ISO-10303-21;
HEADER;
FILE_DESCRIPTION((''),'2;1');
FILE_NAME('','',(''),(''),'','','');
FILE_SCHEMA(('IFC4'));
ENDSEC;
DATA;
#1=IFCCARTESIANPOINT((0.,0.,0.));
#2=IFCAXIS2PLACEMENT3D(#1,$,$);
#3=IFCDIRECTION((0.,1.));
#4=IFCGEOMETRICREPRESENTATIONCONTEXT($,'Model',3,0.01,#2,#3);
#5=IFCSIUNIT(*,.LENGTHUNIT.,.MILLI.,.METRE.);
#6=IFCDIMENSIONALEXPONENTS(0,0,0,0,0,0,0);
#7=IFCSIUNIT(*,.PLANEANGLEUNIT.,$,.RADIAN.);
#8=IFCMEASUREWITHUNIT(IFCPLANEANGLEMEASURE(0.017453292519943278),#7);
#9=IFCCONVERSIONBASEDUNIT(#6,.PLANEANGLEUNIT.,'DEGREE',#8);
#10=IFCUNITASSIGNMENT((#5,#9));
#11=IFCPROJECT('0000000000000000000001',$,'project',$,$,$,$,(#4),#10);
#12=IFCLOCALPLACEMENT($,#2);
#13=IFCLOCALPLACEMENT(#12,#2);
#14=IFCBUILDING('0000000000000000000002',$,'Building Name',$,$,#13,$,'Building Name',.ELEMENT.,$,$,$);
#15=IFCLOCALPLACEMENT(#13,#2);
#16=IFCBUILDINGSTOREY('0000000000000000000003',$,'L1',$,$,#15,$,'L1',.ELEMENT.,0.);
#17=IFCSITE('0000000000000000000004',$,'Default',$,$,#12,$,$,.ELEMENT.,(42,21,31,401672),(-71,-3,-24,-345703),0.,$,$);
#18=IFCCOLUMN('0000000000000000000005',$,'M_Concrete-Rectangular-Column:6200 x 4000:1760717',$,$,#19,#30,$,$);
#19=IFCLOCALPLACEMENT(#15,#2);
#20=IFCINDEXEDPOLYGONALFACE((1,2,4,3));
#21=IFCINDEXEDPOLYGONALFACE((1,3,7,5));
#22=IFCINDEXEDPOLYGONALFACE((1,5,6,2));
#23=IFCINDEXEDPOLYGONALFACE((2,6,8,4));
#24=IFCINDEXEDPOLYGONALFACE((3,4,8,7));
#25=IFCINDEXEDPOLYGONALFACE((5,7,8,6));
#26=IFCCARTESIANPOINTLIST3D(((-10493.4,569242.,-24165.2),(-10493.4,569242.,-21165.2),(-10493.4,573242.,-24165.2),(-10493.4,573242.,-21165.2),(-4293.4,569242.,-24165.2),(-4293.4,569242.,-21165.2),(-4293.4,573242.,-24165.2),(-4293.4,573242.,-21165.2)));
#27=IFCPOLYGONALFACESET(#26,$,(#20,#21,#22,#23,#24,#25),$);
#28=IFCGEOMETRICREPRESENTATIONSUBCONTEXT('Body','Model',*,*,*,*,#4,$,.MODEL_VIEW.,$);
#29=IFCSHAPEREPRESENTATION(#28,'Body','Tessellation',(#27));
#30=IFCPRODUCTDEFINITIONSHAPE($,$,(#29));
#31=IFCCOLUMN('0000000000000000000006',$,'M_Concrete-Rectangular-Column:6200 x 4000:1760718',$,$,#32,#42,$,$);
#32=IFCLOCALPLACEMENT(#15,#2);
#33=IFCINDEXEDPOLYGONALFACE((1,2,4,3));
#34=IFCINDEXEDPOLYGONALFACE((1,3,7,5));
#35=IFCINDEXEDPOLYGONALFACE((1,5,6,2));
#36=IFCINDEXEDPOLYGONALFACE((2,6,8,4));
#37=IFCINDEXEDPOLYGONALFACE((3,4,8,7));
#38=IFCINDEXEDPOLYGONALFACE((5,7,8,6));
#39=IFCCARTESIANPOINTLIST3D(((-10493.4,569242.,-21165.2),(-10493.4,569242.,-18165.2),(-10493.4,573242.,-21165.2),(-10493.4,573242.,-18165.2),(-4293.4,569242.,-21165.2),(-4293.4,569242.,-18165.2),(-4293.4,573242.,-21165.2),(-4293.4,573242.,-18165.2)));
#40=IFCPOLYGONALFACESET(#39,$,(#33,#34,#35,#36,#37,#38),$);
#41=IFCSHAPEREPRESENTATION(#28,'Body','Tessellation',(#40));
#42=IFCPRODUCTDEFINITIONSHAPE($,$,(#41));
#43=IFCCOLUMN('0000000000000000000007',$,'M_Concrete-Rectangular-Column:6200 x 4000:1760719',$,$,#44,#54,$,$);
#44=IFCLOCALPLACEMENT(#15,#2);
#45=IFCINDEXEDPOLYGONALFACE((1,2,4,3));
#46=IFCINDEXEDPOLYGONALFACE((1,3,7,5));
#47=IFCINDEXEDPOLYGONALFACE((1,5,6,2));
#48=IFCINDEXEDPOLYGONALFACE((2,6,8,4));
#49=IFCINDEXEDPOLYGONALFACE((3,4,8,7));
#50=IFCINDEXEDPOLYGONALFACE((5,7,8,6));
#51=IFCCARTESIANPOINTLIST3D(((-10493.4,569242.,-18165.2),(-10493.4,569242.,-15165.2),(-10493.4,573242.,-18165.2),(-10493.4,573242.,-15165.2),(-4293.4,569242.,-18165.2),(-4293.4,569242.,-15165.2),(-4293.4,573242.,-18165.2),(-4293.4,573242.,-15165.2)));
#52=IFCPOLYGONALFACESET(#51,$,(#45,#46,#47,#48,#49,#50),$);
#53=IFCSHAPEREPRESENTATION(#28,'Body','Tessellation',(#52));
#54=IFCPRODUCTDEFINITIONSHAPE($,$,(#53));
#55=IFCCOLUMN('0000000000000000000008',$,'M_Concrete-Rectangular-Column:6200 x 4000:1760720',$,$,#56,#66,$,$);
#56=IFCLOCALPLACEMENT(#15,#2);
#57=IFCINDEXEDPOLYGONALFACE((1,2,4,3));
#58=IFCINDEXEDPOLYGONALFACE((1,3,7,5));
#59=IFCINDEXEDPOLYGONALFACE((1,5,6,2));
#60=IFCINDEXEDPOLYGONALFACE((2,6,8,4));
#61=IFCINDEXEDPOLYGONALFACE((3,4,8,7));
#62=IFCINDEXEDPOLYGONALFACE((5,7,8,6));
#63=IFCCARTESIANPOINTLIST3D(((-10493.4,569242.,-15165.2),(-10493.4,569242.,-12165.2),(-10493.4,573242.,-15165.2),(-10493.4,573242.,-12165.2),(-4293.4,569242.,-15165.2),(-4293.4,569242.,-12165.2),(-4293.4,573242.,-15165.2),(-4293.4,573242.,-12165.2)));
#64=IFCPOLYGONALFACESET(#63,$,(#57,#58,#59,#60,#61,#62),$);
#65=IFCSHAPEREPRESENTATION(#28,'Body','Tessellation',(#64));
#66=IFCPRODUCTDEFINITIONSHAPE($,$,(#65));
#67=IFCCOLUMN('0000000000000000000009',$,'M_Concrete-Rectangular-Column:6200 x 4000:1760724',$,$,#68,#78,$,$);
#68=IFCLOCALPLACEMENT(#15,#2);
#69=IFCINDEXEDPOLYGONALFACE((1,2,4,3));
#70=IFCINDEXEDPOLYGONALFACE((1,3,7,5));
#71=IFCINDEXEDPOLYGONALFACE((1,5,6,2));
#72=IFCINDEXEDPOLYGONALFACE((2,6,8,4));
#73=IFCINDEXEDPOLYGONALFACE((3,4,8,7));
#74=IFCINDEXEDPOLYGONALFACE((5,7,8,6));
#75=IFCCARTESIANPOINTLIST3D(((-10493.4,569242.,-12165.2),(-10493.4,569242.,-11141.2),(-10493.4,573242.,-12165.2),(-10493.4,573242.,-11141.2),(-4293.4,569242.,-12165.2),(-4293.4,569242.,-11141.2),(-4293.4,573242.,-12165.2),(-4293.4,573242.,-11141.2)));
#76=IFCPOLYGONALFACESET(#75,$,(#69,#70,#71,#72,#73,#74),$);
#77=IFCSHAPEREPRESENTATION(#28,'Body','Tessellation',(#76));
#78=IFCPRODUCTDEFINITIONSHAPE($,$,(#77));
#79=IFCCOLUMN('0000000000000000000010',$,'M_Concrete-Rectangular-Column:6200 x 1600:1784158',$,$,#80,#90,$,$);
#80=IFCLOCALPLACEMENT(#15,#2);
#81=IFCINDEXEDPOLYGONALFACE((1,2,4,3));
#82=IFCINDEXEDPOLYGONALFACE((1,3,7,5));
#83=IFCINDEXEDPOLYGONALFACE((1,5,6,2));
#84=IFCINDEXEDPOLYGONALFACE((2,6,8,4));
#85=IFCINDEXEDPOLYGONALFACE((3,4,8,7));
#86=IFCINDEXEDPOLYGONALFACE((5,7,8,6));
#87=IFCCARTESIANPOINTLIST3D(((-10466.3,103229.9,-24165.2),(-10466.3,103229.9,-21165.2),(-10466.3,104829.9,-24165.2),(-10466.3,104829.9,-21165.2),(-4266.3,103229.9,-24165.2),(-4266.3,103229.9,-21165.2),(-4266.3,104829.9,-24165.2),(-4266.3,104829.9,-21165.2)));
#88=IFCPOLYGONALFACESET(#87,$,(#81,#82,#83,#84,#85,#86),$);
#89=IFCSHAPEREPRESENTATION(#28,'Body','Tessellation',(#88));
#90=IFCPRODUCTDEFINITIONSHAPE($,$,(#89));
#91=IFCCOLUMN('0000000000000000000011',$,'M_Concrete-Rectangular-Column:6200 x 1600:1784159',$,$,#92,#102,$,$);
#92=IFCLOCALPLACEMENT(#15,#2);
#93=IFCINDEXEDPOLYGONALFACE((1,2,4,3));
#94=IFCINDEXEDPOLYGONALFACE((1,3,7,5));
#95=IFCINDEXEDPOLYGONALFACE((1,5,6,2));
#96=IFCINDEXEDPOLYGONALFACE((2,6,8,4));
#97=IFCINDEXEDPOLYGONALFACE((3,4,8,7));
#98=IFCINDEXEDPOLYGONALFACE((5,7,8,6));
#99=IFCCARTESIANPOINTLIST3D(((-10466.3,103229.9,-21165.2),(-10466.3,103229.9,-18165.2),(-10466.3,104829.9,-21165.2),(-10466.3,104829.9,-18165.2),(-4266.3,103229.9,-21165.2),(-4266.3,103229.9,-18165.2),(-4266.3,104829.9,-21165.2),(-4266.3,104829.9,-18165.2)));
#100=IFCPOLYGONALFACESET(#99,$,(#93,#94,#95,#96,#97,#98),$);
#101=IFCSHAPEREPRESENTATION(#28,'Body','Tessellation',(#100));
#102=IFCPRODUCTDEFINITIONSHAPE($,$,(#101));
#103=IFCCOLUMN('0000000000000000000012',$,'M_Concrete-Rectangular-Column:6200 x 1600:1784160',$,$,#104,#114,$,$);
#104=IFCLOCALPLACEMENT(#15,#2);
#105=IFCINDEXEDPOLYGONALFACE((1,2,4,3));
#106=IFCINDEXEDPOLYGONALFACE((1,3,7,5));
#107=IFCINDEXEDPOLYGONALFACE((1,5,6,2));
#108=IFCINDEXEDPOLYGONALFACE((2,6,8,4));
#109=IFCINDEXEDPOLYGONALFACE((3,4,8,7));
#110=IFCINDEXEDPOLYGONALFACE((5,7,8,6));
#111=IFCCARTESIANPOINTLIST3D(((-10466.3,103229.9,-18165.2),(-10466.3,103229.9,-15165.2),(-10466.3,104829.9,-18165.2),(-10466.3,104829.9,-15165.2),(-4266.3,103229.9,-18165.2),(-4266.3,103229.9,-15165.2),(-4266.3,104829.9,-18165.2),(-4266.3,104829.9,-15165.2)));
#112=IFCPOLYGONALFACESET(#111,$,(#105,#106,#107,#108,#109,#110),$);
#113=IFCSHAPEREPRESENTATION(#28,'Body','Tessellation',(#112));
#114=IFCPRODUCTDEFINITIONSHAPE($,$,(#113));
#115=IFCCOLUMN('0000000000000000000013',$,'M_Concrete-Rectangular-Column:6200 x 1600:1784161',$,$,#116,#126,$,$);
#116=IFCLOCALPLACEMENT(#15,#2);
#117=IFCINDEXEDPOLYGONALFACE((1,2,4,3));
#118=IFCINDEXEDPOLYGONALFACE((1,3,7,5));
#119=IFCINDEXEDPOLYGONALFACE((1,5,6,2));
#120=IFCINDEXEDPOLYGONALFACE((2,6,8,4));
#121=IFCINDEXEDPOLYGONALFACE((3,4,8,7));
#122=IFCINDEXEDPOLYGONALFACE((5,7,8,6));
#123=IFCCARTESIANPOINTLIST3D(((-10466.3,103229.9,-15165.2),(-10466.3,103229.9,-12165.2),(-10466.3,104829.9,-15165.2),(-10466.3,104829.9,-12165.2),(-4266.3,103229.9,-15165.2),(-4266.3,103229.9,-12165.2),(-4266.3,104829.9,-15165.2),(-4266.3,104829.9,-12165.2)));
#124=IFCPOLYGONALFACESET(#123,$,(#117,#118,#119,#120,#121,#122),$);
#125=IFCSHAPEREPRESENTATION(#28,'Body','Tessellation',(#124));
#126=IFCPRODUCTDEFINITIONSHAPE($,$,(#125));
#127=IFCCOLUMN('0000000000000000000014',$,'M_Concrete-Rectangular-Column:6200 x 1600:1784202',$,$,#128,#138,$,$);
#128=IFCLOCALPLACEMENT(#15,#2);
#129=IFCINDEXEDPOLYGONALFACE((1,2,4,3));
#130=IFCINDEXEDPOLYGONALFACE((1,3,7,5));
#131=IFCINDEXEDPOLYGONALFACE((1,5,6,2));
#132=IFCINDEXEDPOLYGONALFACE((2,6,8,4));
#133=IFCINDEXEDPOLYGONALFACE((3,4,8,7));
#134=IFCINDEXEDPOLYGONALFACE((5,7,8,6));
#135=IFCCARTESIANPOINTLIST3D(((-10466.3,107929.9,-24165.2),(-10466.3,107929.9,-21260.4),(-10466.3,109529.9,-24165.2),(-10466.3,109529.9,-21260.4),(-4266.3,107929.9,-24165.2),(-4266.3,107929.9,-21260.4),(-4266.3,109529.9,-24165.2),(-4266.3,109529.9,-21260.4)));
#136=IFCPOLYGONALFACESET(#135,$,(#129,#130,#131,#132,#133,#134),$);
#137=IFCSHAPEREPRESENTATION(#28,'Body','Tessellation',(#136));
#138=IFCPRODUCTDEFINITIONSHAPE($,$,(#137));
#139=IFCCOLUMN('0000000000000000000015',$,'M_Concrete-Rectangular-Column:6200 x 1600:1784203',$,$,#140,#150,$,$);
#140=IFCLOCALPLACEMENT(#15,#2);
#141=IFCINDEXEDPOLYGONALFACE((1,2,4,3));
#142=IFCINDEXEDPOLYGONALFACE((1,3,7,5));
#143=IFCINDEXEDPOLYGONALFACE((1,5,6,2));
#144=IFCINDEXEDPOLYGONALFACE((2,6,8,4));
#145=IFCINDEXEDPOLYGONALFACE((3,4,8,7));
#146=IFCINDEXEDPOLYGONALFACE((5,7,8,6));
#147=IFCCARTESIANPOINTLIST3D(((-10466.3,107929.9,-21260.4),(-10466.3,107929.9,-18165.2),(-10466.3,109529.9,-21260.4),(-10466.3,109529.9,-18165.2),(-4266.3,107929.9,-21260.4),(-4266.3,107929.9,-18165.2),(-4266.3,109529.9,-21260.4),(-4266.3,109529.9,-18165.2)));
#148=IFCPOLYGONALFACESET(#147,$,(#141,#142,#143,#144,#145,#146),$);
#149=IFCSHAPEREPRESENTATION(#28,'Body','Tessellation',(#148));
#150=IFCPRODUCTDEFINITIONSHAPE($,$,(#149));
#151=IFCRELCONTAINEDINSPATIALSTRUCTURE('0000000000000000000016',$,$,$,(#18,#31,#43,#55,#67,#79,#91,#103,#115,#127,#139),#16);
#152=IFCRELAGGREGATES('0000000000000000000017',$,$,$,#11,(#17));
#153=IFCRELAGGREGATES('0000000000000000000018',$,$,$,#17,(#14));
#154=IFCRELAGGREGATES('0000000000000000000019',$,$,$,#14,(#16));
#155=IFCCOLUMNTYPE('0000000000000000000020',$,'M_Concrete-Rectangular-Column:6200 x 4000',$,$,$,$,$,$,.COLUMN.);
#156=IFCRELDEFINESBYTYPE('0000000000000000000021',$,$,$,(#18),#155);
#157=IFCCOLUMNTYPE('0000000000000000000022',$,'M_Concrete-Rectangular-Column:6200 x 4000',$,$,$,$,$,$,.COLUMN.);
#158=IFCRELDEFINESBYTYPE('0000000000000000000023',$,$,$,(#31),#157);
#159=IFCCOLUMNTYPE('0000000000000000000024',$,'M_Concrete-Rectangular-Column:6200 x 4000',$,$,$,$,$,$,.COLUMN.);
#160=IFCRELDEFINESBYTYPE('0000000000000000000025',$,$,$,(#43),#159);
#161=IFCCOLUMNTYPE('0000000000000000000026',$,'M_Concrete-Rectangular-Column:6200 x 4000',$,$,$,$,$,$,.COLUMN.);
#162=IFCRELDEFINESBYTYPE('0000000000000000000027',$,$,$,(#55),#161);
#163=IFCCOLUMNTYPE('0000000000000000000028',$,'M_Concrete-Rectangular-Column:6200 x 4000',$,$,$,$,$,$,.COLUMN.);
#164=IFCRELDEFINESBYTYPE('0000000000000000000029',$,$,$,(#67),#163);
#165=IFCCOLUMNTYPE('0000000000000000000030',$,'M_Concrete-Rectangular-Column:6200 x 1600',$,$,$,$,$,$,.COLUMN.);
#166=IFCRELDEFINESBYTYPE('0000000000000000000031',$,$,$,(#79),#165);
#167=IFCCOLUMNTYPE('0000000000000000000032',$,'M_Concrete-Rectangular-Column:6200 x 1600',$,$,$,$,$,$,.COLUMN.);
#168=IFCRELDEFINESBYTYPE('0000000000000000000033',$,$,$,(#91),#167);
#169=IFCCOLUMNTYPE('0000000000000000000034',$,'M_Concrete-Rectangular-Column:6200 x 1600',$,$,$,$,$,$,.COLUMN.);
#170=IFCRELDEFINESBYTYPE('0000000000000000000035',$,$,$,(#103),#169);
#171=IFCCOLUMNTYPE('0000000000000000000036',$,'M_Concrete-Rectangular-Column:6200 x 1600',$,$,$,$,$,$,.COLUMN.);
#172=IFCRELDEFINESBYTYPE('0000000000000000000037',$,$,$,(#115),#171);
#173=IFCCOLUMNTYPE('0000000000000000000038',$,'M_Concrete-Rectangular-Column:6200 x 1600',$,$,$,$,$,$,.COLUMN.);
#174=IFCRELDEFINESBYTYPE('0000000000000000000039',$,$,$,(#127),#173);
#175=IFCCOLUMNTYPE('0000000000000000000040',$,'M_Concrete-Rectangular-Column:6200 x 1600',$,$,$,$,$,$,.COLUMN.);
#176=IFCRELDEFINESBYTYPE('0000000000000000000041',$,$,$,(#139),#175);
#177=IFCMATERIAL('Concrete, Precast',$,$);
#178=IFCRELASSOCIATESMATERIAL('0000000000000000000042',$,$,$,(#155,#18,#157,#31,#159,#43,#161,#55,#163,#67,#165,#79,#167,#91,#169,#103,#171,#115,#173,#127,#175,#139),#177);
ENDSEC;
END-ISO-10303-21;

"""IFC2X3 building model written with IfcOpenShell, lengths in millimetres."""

from ifc_helpers import new_model, entity, si_unit, converted_unit, direction, frame, frame_2d, origin, origin_2d_with_axis, place, context, subcontext, project, spatial, rectangle, extrude, source, transform, mapped, material, type_object, type_shapes, element, save


model = new_model("IFC2X3")

# Units and contexts
model_context = context("Model", 3, precision=0.01, world=origin(), true_north=direction((0.0, 1.0)))
body_context = subcontext(model_context, "Body", "Model", "MODEL_VIEW")
ifc_project = project(units=[si_unit("LENGTHUNIT", "METRE", prefix="MILLI"), converted_unit("PLANEANGLEUNIT", "DEGREE", entity("IfcPlaneAngleMeasure", 0.017453292519943278), si_unit("PLANEANGLEUNIT", "RADIAN"), dimensions=[0, 0, 0, 0, 0, 0, 0])], contexts=[model_context])

# Site, building, storey
site_placement = place(None, origin())
site = spatial("IfcSite", under=ifc_project, at=site_placement, Name="Default", CompositionType="ELEMENT", RefLatitude=(42, 21, 31, 401672), RefLongitude=(-71, -3, -24, -345703), RefElevation=0.0)
building_placement = place(site_placement, origin())
building = spatial("IfcBuilding", under=site, at=building_placement, Name="Building Name", LongName="Building Name", CompositionType="ELEMENT")
storey_placement = place(building_placement, origin())
storey = spatial("IfcBuildingStorey", under=building, at=storey_placement, Name="L1", LongName="L1", CompositionType="ELEMENT", Elevation=0.0)

# Columns
ifc_material_1 = material(Name="Concrete, Precast")
column_type_1 = type_object("IfcColumnType", Name="M_Concrete-Rectangular-Column:6200 x 4000", PredefinedType="COLUMN", material=ifc_material_1)
shared_shape_1 = source(origin(), body_context, "Body", "SweptSolid", [
    extrude(rectangle(XDim=4000.0, YDim=6200.0, at=frame_2d((0.0, 0.0), x_axis=(1.0, 0.0))), frame((-7393.4, 571242.0, -24165.2), z_axis=(0.0, 0.0, 1.0), x_axis=(0.0, -1.0, 0.0)), (0.0, 0.0, 1.0), 3000.0),
])
type_shapes(column_type_1, [shared_shape_1])
column_1_placement = place(storey_placement, origin())
element("IfcColumn", 1, at=column_1_placement, inside=storey, type_object=column_type_1, material=ifc_material_1, Name="M_Concrete-Rectangular-Column:6200 x 4000:1760717", context=body_context, shape_type="MappedRepresentation", body=[
    mapped(shared_shape_1, transform((0.0, 0.0, 0.0), scale=1.0)),
])
column_type_2 = type_object("IfcColumnType", Name="M_Concrete-Rectangular-Column:6200 x 4000", PredefinedType="COLUMN", material=ifc_material_1)
shared_shape_2 = source(origin(), body_context, "Body", "SweptSolid", [
    extrude(rectangle(XDim=4000.0, YDim=6200.0, at=frame_2d((0.0, 0.0), x_axis=(1.0, 0.0))), frame((-7393.4, 571242.0, -21165.2), z_axis=(0.0, 0.0, 1.0), x_axis=(0.0, -1.0, 0.0)), (0.0, 0.0, 1.0), 3000.0),
])
type_shapes(column_type_2, [shared_shape_2])
column_2_placement = place(storey_placement, origin())
element("IfcColumn", 2, at=column_2_placement, inside=storey, type_object=column_type_2, material=ifc_material_1, Name="M_Concrete-Rectangular-Column:6200 x 4000:1760718", context=body_context, shape_type="MappedRepresentation", body=[
    mapped(shared_shape_2, transform((0.0, 0.0, 0.0), scale=1.0)),
])
column_type_3 = type_object("IfcColumnType", Name="M_Concrete-Rectangular-Column:6200 x 4000", PredefinedType="COLUMN", material=ifc_material_1)
shared_shape_3 = source(origin(), body_context, "Body", "SweptSolid", [
    extrude(rectangle(XDim=4000.0, YDim=6200.0, at=frame_2d((0.0, 0.0), x_axis=(1.0, 0.0))), frame((-7393.4, 571242.0, -18165.2), z_axis=(0.0, 0.0, 1.0), x_axis=(0.0, -1.0, 0.0)), (0.0, 0.0, 1.0), 3000.0),
])
type_shapes(column_type_3, [shared_shape_3])
column_3_placement = place(storey_placement, origin())
element("IfcColumn", 3, at=column_3_placement, inside=storey, type_object=column_type_3, material=ifc_material_1, Name="M_Concrete-Rectangular-Column:6200 x 4000:1760719", context=body_context, shape_type="MappedRepresentation", body=[
    mapped(shared_shape_3, transform((0.0, 0.0, 0.0), scale=1.0)),
])
column_type_4 = type_object("IfcColumnType", Name="M_Concrete-Rectangular-Column:6200 x 4000", PredefinedType="COLUMN", material=ifc_material_1)
shared_shape_4 = source(origin(), body_context, "Body", "SweptSolid", [
    extrude(rectangle(XDim=4000.0, YDim=6200.0, at=frame_2d((0.0, 0.0), x_axis=(1.0, 0.0))), frame((-7393.4, 571242.0, -15165.2), z_axis=(0.0, 0.0, 1.0), x_axis=(0.0, -1.0, 0.0)), (0.0, 0.0, 1.0), 3000.0),
])
type_shapes(column_type_4, [shared_shape_4])
column_4_placement = place(storey_placement, origin())
element("IfcColumn", 4, at=column_4_placement, inside=storey, type_object=column_type_4, material=ifc_material_1, Name="M_Concrete-Rectangular-Column:6200 x 4000:1760720", context=body_context, shape_type="MappedRepresentation", body=[
    mapped(shared_shape_4, transform((0.0, 0.0, 0.0), scale=1.0)),
])
column_type_5 = type_object("IfcColumnType", Name="M_Concrete-Rectangular-Column:6200 x 4000", PredefinedType="COLUMN", material=ifc_material_1)
shared_shape_5 = source(origin(), body_context, "Body", "SweptSolid", [
    extrude(rectangle(XDim=4000.0, YDim=6200.0, at=origin_2d_with_axis()), frame((-7393.4, 571242.0, -12165.2), z_axis=(0.0, 0.0, 1.0), x_axis=(0.0, -1.0, 0.0)), (0.0, 0.0, 1.0), 1024.0),
])
type_shapes(column_type_5, [shared_shape_5])
column_5_placement = place(storey_placement, origin())
element("IfcColumn", 5, at=column_5_placement, inside=storey, type_object=column_type_5, material=ifc_material_1, Name="M_Concrete-Rectangular-Column:6200 x 4000:1760724", context=body_context, shape_type="MappedRepresentation", body=[
    mapped(shared_shape_5, transform((0.0, 0.0, 0.0), scale=1.0)),
])
column_type_6 = type_object("IfcColumnType", Name="M_Concrete-Rectangular-Column:6200 x 1600", PredefinedType="COLUMN", material=ifc_material_1)
shared_shape_6 = source(origin(), body_context, "Body", "SweptSolid", [
    extrude(rectangle(XDim=1600.0, YDim=6200.0, at=frame_2d((0.0, 0.0), x_axis=(1.0, 0.0))), frame((-7366.3, 104029.9, -24165.2), z_axis=(0.0, 0.0, 1.0), x_axis=(0.0, -1.0, 0.0)), (0.0, 0.0, 1.0), 3000.0),
])
type_shapes(column_type_6, [shared_shape_6])
column_6_placement = place(storey_placement, origin())
element("IfcColumn", 6, at=column_6_placement, inside=storey, type_object=column_type_6, material=ifc_material_1, Name="M_Concrete-Rectangular-Column:6200 x 1600:1784158", context=body_context, shape_type="MappedRepresentation", body=[
    mapped(shared_shape_6, transform((0.0, 0.0, 0.0), scale=1.0)),
])
column_type_7 = type_object("IfcColumnType", Name="M_Concrete-Rectangular-Column:6200 x 1600", PredefinedType="COLUMN", material=ifc_material_1)
shared_shape_7 = source(origin(), body_context, "Body", "SweptSolid", [
    extrude(rectangle(XDim=1600.0, YDim=6200.0, at=frame_2d((0.0, 0.0), x_axis=(1.0, 0.0))), frame((-7366.3, 104029.9, -21165.2), z_axis=(0.0, 0.0, 1.0), x_axis=(0.0, -1.0, 0.0)), (0.0, 0.0, 1.0), 3000.0),
])
type_shapes(column_type_7, [shared_shape_7])
column_7_placement = place(storey_placement, origin())
element("IfcColumn", 7, at=column_7_placement, inside=storey, type_object=column_type_7, material=ifc_material_1, Name="M_Concrete-Rectangular-Column:6200 x 1600:1784159", context=body_context, shape_type="MappedRepresentation", body=[
    mapped(shared_shape_7, transform((0.0, 0.0, 0.0), scale=1.0)),
])
column_type_8 = type_object("IfcColumnType", Name="M_Concrete-Rectangular-Column:6200 x 1600", PredefinedType="COLUMN", material=ifc_material_1)
shared_shape_8 = source(origin(), body_context, "Body", "SweptSolid", [
    extrude(rectangle(XDim=1600.0, YDim=6200.0, at=frame_2d((0.0, 0.0), x_axis=(1.0, 0.0))), frame((-7366.3, 104029.9, -18165.2), z_axis=(0.0, 0.0, 1.0), x_axis=(0.0, -1.0, 0.0)), (0.0, 0.0, 1.0), 3000.0),
])
type_shapes(column_type_8, [shared_shape_8])
column_8_placement = place(storey_placement, origin())
element("IfcColumn", 8, at=column_8_placement, inside=storey, type_object=column_type_8, material=ifc_material_1, Name="M_Concrete-Rectangular-Column:6200 x 1600:1784160", context=body_context, shape_type="MappedRepresentation", body=[
    mapped(shared_shape_8, transform((0.0, 0.0, 0.0), scale=1.0)),
])
column_type_9 = type_object("IfcColumnType", Name="M_Concrete-Rectangular-Column:6200 x 1600", PredefinedType="COLUMN", material=ifc_material_1)
shared_shape_9 = source(origin(), body_context, "Body", "SweptSolid", [
    extrude(rectangle(XDim=1600.0, YDim=6200.0, at=frame_2d((0.0, 0.0), x_axis=(1.0, 0.0))), frame((-7366.3, 104029.9, -15165.2), z_axis=(0.0, 0.0, 1.0), x_axis=(0.0, -1.0, 0.0)), (0.0, 0.0, 1.0), 3000.0),
])
type_shapes(column_type_9, [shared_shape_9])
column_9_placement = place(storey_placement, origin())
element("IfcColumn", 9, at=column_9_placement, inside=storey, type_object=column_type_9, material=ifc_material_1, Name="M_Concrete-Rectangular-Column:6200 x 1600:1784161", context=body_context, shape_type="MappedRepresentation", body=[
    mapped(shared_shape_9, transform((0.0, 0.0, 0.0), scale=1.0)),
])
column_type_10 = type_object("IfcColumnType", Name="M_Concrete-Rectangular-Column:6200 x 1600", PredefinedType="COLUMN", material=ifc_material_1)
shared_shape_10 = source(origin(), body_context, "Body", "SweptSolid", [
    extrude(rectangle(XDim=1600.0, YDim=6200.0, at=frame_2d((0.0, 0.0), x_axis=(1.0, 0.0))), frame((-7366.3, 108729.9, -24165.2), z_axis=(0.0, 0.0, 1.0), x_axis=(0.0, -1.0, 0.0)), (0.0, 0.0, 1.0), 2904.8),
])
type_shapes(column_type_10, [shared_shape_10])
column_10_placement = place(storey_placement, origin())
element("IfcColumn", 10, at=column_10_placement, inside=storey, type_object=column_type_10, material=ifc_material_1, Name="M_Concrete-Rectangular-Column:6200 x 1600:1784202", context=body_context, shape_type="MappedRepresentation", body=[
    mapped(shared_shape_10, transform((0.0, 0.0, 0.0), scale=1.0)),
])
column_type_11 = type_object("IfcColumnType", Name="M_Concrete-Rectangular-Column:6200 x 1600", PredefinedType="COLUMN", material=ifc_material_1)
shared_shape_11 = source(origin(), body_context, "Body", "SweptSolid", [
    extrude(rectangle(XDim=1600.0, YDim=6200.0, at=frame_2d((0.0, 0.0), x_axis=(1.0, 0.0))), frame((-7366.3, 108729.9, -21260.4), z_axis=(0.0, 0.0, 1.0), x_axis=(0.0, -1.0, 0.0)), (0.0, 0.0, 1.0), 3095.2),
])
type_shapes(column_type_11, [shared_shape_11])
column_11_placement = place(storey_placement, origin())
element("IfcColumn", 11, at=column_11_placement, inside=storey, type_object=column_type_11, material=ifc_material_1, Name="M_Concrete-Rectangular-Column:6200 x 1600:1784203", context=body_context, shape_type="MappedRepresentation", body=[
    mapped(shared_shape_11, transform((0.0, 0.0, 0.0), scale=1.0)),
])

save(model, "model.ifc")
